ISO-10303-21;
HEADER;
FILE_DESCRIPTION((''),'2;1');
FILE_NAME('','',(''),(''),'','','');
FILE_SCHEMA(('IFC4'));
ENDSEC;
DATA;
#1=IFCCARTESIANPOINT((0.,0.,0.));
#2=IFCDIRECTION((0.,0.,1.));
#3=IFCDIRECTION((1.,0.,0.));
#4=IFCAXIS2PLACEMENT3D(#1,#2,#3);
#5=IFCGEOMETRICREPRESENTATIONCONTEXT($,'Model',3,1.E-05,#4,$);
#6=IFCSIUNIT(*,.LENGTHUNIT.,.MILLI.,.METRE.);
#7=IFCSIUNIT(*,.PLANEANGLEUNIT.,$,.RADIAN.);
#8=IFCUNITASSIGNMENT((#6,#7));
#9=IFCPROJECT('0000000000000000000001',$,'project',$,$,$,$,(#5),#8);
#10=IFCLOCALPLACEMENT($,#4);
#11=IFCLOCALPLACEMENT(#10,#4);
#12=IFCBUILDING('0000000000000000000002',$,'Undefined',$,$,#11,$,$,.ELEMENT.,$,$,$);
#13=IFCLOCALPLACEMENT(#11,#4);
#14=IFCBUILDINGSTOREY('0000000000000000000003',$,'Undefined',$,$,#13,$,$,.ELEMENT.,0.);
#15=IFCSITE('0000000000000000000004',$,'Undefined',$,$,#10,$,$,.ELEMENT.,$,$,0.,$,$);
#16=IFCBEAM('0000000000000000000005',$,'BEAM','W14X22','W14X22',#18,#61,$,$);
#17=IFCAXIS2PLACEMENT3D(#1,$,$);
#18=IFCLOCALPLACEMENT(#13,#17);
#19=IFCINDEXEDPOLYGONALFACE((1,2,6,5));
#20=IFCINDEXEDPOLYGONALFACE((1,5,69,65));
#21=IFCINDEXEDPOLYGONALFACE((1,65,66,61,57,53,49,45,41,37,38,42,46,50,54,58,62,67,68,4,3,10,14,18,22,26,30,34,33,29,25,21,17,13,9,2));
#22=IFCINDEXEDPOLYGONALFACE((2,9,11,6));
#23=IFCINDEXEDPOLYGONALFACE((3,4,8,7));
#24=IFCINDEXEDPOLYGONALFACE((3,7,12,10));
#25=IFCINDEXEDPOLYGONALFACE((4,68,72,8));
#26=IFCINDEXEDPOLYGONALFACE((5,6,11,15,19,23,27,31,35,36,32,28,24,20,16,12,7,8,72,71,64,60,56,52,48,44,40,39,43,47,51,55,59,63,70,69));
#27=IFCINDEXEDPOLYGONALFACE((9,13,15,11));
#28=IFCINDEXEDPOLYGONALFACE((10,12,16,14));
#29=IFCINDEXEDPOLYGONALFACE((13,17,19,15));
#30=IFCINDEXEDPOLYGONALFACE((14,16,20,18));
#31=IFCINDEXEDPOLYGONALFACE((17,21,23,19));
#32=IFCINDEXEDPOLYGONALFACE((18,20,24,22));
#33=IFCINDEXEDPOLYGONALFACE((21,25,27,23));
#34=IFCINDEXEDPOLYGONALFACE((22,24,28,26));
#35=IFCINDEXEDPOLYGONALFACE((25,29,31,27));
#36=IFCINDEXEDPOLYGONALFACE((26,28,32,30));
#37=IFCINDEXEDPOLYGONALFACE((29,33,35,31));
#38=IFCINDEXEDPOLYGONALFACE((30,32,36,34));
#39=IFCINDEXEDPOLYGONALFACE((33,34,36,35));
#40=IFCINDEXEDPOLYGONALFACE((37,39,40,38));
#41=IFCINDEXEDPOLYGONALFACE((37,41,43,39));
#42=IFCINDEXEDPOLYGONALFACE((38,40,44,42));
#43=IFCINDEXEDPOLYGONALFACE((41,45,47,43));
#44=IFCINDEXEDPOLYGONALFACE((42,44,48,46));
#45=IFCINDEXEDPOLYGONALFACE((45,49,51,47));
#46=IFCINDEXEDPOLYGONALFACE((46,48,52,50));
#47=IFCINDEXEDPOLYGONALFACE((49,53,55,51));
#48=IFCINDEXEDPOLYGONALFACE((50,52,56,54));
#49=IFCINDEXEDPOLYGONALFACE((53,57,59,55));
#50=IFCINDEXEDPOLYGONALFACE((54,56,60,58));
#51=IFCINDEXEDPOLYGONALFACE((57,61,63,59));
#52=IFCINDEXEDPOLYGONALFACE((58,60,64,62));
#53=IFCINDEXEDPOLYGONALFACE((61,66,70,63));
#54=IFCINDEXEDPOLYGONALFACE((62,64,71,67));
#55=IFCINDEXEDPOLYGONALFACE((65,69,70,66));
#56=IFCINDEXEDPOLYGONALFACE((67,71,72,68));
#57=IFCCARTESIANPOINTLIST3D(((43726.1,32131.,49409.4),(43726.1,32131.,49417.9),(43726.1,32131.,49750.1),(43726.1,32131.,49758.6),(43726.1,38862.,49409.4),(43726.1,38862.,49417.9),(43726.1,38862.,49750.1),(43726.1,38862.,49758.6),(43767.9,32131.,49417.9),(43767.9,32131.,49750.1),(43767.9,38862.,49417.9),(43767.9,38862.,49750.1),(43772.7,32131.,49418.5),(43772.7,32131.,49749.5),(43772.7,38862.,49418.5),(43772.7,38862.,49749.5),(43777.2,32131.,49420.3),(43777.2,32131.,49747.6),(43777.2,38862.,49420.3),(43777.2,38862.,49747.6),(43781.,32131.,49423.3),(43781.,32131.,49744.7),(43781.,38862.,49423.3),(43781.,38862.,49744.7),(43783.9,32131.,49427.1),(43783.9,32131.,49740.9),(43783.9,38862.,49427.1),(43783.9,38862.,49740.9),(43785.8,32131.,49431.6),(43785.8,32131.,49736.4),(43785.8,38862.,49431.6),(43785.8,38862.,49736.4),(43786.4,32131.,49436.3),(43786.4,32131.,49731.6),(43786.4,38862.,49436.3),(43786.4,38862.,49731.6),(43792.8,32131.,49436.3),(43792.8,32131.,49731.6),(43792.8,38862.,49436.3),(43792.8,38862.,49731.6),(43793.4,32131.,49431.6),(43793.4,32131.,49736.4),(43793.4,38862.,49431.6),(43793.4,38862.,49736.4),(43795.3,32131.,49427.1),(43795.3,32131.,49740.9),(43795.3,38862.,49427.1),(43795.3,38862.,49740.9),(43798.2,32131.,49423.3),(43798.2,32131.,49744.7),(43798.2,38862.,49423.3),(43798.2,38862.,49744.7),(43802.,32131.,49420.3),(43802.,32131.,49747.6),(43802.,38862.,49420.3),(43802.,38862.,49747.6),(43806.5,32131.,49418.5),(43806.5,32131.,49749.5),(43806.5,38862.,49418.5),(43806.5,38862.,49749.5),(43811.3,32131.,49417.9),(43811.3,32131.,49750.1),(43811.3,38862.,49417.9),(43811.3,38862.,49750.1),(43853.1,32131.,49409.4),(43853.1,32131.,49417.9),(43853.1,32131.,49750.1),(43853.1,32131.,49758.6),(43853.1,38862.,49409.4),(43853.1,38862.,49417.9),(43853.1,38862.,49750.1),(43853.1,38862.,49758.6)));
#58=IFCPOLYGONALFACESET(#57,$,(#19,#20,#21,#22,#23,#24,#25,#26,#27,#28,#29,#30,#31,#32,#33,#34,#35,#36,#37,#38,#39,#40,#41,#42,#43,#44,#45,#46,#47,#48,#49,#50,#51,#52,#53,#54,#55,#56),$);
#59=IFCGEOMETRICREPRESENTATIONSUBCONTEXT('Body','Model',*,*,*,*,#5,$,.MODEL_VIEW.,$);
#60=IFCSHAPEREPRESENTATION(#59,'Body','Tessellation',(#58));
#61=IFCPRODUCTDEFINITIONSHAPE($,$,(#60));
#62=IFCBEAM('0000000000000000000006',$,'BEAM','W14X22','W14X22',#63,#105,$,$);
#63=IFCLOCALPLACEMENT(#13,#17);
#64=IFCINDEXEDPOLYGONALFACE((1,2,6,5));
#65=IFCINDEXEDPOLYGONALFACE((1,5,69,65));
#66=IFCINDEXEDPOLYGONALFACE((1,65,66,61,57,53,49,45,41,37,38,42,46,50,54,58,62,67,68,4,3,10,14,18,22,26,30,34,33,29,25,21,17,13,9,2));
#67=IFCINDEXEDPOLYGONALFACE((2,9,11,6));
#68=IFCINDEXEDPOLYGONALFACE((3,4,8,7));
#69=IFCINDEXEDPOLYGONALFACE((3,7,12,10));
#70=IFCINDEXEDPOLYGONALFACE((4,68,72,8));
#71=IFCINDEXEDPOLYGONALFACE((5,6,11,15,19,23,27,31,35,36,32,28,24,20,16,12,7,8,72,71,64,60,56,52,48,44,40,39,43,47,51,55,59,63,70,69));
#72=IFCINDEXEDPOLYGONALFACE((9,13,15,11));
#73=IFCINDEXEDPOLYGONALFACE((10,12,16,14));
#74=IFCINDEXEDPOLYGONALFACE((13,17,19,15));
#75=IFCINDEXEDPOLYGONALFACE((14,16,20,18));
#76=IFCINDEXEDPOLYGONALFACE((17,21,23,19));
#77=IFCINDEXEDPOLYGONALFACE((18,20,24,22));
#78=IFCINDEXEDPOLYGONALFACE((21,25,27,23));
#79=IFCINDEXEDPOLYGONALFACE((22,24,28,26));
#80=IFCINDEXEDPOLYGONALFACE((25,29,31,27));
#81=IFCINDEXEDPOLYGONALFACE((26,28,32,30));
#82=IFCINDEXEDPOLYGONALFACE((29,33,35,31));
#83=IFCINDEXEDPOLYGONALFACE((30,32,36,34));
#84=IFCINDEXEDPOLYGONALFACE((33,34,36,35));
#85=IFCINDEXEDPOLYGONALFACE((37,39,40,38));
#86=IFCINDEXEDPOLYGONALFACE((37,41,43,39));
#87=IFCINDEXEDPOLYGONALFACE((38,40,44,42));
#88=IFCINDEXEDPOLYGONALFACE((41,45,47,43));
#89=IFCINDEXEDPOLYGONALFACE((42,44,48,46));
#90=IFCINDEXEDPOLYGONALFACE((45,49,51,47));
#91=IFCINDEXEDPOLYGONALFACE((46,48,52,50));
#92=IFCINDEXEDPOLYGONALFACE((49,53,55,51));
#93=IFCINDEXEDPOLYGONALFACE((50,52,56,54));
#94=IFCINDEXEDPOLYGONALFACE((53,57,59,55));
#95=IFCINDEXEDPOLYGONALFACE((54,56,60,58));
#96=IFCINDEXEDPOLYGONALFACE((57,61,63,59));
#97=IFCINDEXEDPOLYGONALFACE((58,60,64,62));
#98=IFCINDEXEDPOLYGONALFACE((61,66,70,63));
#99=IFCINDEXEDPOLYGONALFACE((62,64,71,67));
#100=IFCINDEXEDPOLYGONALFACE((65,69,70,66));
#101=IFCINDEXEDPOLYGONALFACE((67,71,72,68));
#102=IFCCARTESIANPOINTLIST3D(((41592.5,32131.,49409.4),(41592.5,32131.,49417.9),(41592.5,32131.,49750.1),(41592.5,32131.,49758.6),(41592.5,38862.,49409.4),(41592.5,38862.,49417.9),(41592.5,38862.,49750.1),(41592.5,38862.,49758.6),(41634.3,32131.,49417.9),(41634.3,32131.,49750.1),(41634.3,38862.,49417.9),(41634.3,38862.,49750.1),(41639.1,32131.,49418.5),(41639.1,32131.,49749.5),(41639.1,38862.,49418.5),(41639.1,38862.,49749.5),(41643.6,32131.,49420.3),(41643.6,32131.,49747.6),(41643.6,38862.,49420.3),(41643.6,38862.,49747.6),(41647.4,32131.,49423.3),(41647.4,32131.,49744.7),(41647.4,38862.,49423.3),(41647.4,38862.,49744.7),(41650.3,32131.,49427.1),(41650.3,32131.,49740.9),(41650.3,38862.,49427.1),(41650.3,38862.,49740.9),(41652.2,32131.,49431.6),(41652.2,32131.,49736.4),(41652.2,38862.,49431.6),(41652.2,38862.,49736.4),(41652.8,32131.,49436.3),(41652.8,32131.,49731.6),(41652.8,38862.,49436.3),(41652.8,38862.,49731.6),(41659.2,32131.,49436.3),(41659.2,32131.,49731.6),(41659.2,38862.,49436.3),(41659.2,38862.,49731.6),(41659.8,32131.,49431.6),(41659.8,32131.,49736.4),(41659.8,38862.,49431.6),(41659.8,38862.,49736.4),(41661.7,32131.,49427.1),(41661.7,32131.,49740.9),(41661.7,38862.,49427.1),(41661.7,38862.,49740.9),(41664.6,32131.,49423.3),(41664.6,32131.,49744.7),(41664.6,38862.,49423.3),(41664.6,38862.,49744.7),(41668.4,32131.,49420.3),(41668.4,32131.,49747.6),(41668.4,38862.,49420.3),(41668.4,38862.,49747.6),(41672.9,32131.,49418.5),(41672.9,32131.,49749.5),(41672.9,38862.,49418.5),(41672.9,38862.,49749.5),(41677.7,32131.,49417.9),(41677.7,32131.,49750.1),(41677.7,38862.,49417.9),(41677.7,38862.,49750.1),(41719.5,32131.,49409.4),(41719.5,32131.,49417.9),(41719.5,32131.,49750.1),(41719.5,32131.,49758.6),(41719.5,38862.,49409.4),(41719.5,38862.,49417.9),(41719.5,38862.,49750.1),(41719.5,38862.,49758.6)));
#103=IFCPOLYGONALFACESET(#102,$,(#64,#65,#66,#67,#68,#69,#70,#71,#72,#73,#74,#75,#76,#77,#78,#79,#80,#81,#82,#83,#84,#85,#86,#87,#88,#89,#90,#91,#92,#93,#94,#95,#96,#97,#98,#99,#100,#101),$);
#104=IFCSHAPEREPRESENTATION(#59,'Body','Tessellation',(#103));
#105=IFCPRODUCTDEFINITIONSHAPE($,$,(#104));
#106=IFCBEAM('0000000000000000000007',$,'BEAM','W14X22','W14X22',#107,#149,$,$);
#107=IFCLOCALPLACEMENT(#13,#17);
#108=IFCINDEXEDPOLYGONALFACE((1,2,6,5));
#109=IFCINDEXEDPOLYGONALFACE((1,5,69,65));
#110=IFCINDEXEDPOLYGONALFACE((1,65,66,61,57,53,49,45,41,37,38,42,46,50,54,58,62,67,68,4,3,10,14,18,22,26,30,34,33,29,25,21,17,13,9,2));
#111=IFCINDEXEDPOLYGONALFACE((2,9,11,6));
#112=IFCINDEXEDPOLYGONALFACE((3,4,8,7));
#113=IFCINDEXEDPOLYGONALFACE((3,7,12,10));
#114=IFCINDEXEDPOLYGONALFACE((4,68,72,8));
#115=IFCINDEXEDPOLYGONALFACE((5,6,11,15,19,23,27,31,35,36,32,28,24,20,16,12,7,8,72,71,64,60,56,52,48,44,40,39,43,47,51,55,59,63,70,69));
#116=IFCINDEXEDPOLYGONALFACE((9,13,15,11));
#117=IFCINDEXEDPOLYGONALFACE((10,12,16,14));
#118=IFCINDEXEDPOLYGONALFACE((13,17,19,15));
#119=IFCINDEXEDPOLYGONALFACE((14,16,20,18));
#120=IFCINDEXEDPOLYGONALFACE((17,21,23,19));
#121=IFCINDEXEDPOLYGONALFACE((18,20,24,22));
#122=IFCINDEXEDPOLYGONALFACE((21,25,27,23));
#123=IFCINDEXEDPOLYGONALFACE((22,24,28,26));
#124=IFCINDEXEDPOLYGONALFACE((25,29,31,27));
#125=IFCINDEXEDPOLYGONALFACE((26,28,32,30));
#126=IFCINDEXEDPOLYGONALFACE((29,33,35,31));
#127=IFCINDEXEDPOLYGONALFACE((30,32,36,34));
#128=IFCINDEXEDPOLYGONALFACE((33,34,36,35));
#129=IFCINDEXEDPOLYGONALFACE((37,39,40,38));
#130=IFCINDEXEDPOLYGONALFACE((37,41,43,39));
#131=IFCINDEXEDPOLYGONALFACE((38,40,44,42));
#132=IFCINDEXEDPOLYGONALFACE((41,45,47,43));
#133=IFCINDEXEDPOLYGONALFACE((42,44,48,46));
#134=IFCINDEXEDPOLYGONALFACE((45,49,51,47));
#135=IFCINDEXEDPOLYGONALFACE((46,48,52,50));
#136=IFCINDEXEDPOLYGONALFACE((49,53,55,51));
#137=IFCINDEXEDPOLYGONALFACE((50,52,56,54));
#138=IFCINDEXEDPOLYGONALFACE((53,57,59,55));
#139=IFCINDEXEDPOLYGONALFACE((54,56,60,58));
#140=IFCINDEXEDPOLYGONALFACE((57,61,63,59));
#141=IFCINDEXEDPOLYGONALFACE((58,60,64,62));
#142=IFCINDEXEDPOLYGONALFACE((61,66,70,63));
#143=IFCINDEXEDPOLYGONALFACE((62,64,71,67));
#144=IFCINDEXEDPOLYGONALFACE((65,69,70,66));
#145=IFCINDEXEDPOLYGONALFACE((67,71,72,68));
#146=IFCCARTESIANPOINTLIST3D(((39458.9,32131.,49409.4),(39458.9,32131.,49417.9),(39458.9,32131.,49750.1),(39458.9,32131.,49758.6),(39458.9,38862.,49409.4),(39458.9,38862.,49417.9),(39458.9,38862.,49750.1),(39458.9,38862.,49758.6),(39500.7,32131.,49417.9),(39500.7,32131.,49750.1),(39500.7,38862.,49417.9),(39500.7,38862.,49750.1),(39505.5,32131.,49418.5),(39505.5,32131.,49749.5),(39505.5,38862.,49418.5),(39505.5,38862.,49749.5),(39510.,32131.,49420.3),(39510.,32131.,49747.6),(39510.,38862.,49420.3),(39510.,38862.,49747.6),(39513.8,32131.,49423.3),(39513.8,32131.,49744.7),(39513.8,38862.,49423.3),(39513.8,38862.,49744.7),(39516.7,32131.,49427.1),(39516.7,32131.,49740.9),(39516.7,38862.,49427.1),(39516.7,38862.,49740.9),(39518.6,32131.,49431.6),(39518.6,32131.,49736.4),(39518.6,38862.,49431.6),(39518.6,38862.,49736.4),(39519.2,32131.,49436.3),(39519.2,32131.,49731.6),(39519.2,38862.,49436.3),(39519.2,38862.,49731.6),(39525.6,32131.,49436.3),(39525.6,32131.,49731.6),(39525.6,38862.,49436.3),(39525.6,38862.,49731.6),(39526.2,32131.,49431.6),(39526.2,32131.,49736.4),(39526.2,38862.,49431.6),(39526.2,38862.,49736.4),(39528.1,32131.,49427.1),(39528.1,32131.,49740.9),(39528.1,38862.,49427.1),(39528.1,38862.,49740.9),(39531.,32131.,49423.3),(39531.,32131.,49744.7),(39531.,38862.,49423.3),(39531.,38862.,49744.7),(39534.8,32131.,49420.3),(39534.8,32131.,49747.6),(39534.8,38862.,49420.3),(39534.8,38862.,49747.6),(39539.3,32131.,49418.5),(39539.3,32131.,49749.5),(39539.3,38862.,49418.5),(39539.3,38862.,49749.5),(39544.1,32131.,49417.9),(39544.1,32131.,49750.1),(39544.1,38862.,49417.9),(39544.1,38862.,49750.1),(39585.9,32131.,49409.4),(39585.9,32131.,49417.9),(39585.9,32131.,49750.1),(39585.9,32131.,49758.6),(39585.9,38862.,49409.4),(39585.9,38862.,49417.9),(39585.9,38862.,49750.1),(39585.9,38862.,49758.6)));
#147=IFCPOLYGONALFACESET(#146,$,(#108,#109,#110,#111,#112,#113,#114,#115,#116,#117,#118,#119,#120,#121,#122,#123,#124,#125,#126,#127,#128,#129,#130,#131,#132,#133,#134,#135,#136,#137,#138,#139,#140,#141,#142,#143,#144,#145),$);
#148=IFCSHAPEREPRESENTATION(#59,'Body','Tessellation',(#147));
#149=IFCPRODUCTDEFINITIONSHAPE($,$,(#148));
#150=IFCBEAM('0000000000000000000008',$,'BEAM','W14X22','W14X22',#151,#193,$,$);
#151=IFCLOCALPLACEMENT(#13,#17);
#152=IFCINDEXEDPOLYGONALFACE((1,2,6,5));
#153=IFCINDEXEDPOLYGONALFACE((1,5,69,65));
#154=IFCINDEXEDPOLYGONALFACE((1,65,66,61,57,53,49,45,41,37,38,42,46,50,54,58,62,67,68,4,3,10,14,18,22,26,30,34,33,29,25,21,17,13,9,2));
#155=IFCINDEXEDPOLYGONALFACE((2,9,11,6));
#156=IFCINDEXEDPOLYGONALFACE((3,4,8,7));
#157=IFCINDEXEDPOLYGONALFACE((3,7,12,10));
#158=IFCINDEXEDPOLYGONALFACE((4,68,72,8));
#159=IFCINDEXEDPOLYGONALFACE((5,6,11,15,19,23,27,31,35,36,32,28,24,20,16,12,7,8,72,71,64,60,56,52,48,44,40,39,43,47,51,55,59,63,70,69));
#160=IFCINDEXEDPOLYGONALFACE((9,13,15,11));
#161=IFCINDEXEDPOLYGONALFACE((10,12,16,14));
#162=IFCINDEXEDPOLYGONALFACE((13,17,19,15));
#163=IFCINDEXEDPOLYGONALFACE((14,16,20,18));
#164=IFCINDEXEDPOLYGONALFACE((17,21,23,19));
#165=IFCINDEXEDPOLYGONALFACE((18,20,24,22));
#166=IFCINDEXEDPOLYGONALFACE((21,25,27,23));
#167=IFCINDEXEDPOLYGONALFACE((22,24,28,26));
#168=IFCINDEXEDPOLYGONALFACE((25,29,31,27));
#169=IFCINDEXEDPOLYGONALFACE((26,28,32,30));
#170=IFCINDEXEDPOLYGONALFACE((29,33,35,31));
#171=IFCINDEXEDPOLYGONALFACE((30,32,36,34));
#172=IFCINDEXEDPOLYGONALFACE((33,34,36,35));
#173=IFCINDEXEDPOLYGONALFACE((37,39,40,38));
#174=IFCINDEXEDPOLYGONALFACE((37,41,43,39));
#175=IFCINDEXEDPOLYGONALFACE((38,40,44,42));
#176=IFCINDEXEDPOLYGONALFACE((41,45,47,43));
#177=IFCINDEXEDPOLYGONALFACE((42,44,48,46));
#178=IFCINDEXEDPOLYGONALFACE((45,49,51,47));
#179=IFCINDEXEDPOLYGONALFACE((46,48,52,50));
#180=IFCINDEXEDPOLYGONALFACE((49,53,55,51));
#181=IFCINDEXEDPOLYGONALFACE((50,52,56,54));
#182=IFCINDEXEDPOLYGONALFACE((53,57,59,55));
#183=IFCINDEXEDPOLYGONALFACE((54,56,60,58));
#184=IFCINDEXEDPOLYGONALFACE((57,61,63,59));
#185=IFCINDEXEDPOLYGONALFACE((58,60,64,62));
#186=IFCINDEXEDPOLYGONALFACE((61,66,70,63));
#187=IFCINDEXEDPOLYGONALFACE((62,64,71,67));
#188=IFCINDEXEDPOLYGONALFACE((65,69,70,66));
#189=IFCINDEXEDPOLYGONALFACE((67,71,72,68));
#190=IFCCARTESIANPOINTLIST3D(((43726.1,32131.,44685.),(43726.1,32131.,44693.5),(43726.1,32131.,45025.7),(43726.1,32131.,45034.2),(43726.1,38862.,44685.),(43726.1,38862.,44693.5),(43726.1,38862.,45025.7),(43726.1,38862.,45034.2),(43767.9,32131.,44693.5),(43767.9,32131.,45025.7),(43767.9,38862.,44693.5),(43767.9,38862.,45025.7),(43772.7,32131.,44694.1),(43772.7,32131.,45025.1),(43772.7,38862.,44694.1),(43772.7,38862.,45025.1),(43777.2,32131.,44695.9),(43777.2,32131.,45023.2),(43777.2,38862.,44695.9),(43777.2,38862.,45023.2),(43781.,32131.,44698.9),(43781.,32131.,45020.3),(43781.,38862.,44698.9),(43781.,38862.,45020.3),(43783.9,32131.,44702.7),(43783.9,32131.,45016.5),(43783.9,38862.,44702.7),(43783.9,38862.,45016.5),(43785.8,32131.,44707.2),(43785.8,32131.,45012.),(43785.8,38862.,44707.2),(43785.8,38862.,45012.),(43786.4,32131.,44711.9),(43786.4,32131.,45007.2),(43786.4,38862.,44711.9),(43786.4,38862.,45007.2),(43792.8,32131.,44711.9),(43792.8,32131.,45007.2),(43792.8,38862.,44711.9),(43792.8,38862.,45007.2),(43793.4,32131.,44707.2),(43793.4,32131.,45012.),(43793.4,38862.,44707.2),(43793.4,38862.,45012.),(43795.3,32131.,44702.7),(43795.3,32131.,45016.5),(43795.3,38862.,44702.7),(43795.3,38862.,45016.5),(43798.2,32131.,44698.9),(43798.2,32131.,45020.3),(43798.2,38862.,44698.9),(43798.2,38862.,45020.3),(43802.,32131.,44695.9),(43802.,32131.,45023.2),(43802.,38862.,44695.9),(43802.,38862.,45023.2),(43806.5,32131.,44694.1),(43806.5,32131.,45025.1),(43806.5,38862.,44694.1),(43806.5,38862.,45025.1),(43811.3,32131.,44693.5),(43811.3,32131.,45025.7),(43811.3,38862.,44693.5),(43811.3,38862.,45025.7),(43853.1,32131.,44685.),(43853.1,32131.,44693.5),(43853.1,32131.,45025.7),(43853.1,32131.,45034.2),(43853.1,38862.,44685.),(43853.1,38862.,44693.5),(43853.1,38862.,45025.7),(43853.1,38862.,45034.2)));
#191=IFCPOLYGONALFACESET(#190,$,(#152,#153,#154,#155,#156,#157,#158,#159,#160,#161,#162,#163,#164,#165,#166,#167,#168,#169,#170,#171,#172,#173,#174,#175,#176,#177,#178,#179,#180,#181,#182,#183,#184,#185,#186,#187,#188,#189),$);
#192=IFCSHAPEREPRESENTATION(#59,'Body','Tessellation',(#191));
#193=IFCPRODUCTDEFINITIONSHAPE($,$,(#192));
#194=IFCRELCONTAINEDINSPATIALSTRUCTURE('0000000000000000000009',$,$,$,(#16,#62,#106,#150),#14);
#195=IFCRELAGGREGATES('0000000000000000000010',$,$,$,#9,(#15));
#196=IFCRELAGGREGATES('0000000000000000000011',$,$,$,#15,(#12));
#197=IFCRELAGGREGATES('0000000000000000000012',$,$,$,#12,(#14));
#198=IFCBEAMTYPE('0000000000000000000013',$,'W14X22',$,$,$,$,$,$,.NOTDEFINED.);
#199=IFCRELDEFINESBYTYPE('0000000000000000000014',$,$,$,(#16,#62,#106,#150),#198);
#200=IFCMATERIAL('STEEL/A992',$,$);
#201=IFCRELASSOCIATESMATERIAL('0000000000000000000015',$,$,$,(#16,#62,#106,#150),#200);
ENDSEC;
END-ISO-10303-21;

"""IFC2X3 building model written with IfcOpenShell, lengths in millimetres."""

from ifc_helpers import new_model, si_unit, frame, origin_with_axes, origin_2d_with_axis, place, context, subcontext, project, spatial, i_section, extrude, material, type_object, element, save


model = new_model("IFC2X3")

# Units and contexts
model_context = context("Model", 3, precision=1e-05, world=origin_with_axes())
body_context = subcontext(model_context, "Body", "Model", "MODEL_VIEW")
ifc_project = project(units=[si_unit("LENGTHUNIT", "METRE", prefix="MILLI"), si_unit("PLANEANGLEUNIT", "RADIAN")], contexts=[model_context])

# Site, building, storey
site_placement = place(None, origin_with_axes())
site = spatial("IfcSite", under=ifc_project, at=site_placement, Name="Undefined", CompositionType="ELEMENT", RefElevation=0.0)
building_placement = place(site_placement, origin_with_axes())
building = spatial("IfcBuilding", under=site, at=building_placement, Name="Undefined", CompositionType="ELEMENT")
storey_placement = place(building_placement, origin_with_axes())
storey = spatial("IfcBuildingStorey", under=building, at=storey_placement, Name="Undefined", CompositionType="ELEMENT", Elevation=0.0)

# Shared definitions
ifc_material = material(Name="STEEL/A992")

# Beams
beam_type_1 = type_object("IfcBeamType", Name="W14X22", PredefinedType="NOTDEFINED")
for number, where, z_axis, x_axis, name in (
    (1, (43789.6, 32131.0, 49584.0), (0.0, 0.0, 1.0), (0.0, 1.0, 0.0), "BEAM"),
    (2, (41656.0, 32131.0, 49584.0), (0.0, 0.0, 1.0), (0.0, 1.0, 0.0), "BEAM"),
    (3, (39522.4, 32131.0, 49584.0), (0.0, 0.0, 1.0), (0.0, 1.0, 0.0), "BEAM"),
    (4, (43789.6, 32131.0, 44859.6), (0.0, 0.0, 1.0), (0.0, 1.0, 0.0), "BEAM"),
):
    element("IfcBeam", number, at=place(storey_placement, frame(where, z_axis=z_axis, x_axis=x_axis)), inside=storey, type_object=beam_type_1, material=ifc_material, Name=name, Description="W14X22", ObjectType="W14X22", context=body_context, shape_type="SweptSolid", body=[
        extrude(i_section(OverallWidth=127.0, OverallDepth=349.2, WebThickness=6.3, FlangeThickness=8.5, FilletRadius=18.5, at=origin_2d_with_axis()), frame((6731.0, 0.0, 0.0), z_axis=(-1.0, 0.0, 0.0), x_axis=(0.0, -1.0, 0.0)), (0.0, 0.0, 1.0), 6731.0),
    ])

save(model, "model.ifc")
